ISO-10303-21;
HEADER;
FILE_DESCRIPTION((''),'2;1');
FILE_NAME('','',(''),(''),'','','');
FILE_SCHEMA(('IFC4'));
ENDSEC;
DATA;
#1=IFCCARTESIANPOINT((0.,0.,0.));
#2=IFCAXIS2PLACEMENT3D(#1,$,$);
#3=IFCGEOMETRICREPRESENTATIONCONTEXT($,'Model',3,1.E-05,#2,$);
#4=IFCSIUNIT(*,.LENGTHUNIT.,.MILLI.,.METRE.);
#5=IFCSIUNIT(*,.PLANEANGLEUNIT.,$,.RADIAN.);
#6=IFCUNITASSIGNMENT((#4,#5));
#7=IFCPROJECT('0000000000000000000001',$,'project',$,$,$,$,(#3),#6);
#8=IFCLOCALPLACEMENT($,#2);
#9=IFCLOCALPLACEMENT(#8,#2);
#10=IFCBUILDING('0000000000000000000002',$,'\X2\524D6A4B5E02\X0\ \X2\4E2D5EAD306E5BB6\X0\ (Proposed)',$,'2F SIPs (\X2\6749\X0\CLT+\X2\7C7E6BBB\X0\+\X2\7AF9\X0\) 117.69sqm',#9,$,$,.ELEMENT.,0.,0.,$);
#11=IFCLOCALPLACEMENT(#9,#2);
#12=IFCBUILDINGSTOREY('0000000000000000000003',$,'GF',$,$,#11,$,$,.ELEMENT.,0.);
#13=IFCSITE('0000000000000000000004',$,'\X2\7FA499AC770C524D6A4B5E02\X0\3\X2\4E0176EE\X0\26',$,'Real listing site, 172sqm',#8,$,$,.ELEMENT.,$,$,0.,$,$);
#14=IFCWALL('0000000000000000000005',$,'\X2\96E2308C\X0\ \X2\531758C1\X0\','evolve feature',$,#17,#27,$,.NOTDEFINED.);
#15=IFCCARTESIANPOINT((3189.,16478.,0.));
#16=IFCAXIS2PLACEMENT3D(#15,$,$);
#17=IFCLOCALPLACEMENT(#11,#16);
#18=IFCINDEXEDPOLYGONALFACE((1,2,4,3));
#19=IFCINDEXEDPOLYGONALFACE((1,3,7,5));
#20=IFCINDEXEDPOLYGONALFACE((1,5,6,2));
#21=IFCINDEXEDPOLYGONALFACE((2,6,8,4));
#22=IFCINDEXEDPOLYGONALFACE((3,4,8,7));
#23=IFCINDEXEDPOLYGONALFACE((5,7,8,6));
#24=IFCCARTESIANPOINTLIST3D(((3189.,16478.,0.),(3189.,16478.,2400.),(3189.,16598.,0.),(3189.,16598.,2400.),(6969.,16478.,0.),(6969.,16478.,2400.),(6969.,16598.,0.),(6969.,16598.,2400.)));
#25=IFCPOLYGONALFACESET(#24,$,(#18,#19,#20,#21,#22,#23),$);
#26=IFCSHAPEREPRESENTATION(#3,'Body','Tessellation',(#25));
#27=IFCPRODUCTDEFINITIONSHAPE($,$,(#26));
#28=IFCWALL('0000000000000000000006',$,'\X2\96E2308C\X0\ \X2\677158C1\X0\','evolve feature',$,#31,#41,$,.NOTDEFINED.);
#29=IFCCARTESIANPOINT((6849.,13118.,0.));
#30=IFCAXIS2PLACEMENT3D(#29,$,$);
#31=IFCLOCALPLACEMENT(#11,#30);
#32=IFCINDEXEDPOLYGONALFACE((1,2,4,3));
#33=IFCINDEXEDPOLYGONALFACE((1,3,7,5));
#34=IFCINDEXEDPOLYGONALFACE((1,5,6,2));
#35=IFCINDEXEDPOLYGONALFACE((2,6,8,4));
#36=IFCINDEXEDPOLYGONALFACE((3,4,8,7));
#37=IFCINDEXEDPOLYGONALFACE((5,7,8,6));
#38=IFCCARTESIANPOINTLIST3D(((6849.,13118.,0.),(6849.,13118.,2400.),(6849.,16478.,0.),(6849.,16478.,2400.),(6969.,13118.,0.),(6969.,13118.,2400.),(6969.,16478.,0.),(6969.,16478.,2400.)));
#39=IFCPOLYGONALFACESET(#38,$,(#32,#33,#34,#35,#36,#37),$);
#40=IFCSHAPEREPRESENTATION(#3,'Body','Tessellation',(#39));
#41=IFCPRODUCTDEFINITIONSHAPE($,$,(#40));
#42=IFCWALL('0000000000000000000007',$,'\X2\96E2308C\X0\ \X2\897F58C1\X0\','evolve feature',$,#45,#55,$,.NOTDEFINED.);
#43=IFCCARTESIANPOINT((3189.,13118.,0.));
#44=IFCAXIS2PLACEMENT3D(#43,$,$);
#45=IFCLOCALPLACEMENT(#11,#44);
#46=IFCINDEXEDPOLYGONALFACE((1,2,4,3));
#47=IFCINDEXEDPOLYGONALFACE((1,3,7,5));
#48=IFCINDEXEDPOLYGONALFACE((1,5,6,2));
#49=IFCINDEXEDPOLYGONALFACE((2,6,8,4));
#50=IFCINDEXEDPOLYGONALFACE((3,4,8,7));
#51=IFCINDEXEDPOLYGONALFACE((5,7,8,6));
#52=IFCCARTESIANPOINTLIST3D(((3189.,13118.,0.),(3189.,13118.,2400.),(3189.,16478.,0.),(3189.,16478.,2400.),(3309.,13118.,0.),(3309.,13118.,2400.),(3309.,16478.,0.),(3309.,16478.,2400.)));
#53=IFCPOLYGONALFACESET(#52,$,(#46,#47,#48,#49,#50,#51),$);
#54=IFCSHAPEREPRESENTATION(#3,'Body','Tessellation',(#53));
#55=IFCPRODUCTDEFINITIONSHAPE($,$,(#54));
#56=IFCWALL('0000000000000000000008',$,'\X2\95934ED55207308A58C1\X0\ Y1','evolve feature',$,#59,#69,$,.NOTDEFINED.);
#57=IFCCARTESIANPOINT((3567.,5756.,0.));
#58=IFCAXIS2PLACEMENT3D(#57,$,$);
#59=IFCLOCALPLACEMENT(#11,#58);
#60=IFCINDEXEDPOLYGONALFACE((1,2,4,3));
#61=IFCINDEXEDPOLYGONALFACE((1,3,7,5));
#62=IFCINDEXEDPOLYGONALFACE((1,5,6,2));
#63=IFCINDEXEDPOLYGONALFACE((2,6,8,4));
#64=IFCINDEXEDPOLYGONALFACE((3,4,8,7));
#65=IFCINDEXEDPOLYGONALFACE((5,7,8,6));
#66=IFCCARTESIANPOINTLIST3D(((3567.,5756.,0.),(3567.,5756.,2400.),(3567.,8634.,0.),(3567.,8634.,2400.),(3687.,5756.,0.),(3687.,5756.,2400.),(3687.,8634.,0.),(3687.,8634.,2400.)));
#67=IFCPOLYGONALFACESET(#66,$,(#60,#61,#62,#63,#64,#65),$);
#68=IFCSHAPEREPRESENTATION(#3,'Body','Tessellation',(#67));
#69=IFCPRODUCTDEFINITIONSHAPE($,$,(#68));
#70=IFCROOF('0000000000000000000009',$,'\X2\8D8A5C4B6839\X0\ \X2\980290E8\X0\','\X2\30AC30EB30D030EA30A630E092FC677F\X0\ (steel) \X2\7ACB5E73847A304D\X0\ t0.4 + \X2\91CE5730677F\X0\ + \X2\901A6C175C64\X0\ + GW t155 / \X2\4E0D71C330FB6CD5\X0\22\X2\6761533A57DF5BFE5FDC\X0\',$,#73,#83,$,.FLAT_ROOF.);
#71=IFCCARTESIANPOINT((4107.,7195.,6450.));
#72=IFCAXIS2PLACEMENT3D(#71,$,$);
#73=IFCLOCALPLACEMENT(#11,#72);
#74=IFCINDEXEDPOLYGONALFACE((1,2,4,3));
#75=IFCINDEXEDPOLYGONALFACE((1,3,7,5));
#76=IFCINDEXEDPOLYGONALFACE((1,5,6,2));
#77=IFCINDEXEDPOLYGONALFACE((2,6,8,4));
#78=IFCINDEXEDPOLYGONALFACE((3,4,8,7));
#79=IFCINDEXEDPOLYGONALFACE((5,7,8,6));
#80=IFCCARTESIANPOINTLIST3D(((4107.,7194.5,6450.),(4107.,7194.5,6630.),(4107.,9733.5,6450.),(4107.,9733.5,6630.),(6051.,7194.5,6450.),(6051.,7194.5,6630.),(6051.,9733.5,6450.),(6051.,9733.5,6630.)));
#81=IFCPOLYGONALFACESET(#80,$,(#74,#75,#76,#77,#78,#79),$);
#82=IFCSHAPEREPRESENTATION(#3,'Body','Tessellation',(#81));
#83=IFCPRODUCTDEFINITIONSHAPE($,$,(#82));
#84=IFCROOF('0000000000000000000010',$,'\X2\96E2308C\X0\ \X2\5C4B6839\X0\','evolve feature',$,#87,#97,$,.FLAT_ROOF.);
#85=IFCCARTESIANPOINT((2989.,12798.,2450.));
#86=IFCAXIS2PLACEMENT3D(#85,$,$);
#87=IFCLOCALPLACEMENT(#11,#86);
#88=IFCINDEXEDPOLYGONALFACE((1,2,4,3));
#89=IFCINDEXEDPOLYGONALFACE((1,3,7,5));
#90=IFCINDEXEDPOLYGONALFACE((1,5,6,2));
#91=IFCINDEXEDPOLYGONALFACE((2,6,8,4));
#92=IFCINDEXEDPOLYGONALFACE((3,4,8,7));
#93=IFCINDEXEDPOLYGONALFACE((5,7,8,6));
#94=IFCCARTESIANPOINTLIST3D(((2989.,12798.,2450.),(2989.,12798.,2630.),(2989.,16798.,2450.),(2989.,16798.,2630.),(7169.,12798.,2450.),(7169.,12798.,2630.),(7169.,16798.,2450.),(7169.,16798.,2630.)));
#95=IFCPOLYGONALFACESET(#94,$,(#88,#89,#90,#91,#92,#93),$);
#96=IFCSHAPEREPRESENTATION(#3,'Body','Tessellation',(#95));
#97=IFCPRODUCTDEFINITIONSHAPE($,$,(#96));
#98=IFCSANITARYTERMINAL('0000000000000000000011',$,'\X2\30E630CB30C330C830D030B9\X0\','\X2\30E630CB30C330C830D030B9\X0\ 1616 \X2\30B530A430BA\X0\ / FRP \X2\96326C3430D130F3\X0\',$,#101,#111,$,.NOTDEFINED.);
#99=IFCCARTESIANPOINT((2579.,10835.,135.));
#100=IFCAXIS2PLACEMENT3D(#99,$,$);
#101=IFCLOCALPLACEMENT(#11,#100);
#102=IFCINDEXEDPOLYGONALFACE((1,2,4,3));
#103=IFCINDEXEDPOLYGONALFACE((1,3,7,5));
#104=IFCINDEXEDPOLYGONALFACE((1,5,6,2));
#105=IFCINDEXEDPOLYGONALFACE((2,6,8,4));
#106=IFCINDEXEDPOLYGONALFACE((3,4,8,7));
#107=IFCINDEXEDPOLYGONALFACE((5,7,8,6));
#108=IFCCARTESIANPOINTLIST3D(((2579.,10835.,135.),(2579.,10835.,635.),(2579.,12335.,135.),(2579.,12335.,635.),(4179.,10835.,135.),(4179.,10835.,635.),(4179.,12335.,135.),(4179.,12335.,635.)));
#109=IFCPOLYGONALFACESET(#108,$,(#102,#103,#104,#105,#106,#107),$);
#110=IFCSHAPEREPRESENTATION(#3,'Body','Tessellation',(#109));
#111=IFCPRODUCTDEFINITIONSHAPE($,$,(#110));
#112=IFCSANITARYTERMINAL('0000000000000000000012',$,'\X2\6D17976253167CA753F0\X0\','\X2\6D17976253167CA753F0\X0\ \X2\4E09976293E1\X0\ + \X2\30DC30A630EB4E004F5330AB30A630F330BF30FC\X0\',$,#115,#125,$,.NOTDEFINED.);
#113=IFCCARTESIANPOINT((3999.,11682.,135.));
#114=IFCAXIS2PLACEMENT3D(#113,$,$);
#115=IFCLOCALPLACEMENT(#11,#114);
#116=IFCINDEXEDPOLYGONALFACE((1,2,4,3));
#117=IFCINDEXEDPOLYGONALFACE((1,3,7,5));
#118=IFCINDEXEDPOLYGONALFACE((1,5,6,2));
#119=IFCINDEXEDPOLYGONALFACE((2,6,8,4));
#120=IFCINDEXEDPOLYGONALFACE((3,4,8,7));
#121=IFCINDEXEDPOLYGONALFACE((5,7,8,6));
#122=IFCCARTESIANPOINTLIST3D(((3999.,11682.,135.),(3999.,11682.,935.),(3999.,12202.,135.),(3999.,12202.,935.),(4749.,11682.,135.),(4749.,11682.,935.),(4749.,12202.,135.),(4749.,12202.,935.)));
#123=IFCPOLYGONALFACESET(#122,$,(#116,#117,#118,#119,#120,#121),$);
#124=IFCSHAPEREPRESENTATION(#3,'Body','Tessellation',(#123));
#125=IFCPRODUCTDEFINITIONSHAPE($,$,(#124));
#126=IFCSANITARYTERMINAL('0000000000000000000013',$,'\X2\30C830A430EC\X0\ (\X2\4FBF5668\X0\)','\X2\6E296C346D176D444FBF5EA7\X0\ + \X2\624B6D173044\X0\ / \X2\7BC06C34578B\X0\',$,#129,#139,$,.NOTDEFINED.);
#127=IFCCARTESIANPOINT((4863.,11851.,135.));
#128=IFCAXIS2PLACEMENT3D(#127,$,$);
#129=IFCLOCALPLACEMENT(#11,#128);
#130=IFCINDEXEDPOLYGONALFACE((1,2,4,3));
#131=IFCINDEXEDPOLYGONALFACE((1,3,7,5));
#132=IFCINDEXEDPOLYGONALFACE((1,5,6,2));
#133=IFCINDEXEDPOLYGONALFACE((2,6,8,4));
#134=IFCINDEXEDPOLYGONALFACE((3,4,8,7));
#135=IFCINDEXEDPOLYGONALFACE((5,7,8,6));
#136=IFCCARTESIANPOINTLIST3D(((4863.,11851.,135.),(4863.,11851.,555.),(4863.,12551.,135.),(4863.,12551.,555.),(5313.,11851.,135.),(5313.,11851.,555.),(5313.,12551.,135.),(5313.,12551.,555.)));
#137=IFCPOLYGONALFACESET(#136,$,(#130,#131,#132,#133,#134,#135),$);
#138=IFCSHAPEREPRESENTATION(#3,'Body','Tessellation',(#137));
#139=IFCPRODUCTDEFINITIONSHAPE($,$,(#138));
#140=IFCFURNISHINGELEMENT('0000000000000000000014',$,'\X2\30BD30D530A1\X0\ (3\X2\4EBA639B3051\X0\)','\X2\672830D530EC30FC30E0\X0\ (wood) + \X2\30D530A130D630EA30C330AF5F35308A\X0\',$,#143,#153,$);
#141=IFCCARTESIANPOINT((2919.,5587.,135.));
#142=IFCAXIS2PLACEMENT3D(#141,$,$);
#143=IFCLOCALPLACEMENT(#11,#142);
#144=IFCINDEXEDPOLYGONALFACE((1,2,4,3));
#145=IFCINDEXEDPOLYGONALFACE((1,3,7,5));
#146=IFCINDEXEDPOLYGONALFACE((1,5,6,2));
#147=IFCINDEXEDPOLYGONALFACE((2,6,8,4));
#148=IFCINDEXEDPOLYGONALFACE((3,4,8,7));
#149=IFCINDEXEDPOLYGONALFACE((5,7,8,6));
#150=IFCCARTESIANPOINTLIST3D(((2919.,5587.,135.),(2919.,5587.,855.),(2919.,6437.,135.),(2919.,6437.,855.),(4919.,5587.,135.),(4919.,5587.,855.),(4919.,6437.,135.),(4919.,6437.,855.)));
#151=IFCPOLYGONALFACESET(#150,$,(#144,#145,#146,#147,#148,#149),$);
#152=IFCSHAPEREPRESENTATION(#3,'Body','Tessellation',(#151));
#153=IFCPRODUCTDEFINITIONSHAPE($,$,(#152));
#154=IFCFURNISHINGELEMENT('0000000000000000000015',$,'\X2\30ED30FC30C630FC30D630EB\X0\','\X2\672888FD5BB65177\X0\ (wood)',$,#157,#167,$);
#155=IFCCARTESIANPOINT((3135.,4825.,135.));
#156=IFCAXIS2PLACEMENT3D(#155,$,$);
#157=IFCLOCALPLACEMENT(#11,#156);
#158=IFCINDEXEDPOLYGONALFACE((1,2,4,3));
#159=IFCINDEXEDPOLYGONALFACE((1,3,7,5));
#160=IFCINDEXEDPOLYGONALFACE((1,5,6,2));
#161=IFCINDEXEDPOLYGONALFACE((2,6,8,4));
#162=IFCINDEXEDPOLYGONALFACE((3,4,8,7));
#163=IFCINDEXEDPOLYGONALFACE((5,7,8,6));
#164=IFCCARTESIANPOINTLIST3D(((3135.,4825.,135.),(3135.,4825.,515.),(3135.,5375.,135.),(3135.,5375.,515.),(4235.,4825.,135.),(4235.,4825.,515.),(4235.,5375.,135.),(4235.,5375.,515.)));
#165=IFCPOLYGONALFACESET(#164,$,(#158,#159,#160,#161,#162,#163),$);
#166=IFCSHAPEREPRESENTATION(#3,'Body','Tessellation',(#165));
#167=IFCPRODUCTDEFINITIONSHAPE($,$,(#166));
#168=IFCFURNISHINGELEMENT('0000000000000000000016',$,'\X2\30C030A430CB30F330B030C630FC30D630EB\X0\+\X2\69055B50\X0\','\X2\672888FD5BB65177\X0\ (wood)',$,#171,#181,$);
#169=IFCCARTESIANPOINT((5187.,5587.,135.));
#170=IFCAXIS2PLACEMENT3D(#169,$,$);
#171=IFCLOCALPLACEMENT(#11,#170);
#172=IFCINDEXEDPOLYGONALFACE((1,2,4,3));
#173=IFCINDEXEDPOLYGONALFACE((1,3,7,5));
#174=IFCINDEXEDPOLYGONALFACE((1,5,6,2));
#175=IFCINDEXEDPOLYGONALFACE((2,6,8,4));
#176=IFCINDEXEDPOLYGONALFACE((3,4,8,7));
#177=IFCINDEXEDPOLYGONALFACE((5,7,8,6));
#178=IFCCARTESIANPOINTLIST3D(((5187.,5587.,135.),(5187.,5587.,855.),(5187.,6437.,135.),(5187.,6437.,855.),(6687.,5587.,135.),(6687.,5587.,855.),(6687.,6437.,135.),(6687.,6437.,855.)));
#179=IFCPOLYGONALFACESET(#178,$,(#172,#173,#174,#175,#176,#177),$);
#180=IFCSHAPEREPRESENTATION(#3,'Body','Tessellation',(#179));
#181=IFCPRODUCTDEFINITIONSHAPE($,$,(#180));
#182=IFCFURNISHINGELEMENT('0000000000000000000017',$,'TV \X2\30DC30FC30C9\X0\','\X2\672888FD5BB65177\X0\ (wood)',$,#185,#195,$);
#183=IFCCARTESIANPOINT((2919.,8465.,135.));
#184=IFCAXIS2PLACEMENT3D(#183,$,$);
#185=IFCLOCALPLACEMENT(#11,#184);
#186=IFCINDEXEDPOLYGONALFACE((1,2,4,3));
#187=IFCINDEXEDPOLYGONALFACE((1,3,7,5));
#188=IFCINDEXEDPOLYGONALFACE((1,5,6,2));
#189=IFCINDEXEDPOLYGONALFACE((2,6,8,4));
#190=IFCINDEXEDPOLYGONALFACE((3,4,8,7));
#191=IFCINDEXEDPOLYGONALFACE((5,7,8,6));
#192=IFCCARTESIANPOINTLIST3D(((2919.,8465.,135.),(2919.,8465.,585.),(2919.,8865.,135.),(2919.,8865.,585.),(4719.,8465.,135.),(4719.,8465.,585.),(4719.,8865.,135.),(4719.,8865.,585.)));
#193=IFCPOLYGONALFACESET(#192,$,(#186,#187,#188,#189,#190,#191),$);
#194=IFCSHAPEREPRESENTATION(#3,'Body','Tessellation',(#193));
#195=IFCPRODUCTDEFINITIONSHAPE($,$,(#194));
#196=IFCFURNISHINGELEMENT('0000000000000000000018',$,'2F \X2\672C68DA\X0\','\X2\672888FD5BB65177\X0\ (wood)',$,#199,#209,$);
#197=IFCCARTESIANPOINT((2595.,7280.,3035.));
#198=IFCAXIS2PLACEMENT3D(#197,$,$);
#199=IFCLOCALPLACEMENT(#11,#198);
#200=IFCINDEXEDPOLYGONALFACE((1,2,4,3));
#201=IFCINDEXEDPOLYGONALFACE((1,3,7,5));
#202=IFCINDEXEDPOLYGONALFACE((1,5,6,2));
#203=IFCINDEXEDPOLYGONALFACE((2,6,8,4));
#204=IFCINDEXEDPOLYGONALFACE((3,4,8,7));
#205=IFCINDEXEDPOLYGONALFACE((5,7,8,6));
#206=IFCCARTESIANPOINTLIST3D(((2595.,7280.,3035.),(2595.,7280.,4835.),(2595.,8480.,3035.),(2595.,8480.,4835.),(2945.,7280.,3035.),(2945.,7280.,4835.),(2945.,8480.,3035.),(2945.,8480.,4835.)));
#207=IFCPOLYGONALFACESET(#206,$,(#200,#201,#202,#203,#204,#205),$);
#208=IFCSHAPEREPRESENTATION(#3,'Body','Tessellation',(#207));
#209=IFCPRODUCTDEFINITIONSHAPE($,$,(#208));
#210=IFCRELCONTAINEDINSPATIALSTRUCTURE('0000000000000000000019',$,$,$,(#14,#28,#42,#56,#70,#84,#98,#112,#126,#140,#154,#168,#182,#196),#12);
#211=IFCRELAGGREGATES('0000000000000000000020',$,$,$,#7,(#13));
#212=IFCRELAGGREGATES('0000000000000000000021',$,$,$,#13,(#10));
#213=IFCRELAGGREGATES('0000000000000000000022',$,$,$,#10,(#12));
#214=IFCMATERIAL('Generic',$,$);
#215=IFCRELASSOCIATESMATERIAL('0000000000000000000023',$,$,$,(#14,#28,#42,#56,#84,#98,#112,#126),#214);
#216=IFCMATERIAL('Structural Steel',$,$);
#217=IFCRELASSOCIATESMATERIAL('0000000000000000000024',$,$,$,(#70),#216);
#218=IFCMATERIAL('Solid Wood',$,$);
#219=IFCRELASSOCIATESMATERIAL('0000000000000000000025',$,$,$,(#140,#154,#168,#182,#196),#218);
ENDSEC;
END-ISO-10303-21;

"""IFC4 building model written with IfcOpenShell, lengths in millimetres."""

from ifc_helpers import new_model, si_unit, frame, frame_2d, origin, place, context, project, spatial, rectangle, extrude, material, element, save


model = new_model("IFC4")

# Units and contexts
model_context = context("Model", 3, precision=1e-05, world=origin())
ifc_project = project(units=[si_unit("LENGTHUNIT", "METRE", prefix="MILLI"), si_unit("PLANEANGLEUNIT", "RADIAN")], contexts=[model_context])

# Site, building, storey
site_placement = place(None, origin())
site = spatial("IfcSite", under=ifc_project, at=site_placement, Name="群馬県前橋市3丁目26", ObjectType="Real listing site, 172sqm", CompositionType="ELEMENT", RefElevation=0.0)
building_placement = place(site_placement, origin())
building = spatial("IfcBuilding", under=site, at=building_placement, Name="前橋市 中庭の家 (Proposed)", ObjectType="2F SIPs (杉CLT+籾殻+竹) 117.69sqm", CompositionType="ELEMENT", ElevationOfRefHeight=0.0, ElevationOfTerrain=0.0)
storey_placement = place(building_placement, origin())
storey = spatial("IfcBuildingStorey", under=building, at=storey_placement, Name="GF", CompositionType="ELEMENT", Elevation=0.0)

# Shared definitions
ifc_material_1 = material(Name="Generic")

# Shared definitions
ifc_material_2 = material(Name="Solid Wood")

# Walls
wall_1_placement = place(storey_placement, frame((3189.0, 16478.0, 0.0)))
element("IfcWall", 1, at=wall_1_placement, inside=storey, material=ifc_material_1, Name="離れ 北壁", Description="evolve feature", PredefinedType="NOTDEFINED", context=model_context, shape_type="SweptSolid", body=[
    extrude(rectangle(XDim=3780.0, YDim=120.0, at=frame_2d((1890.0, 60.0))), frame((3189.0, 16478.0, 0.0)), (0.0, 0.0, 1.0), 2400.0),
])
wall_2_placement = place(storey_placement, frame((6849.0, 13118.0, 0.0)))
element("IfcWall", 2, at=wall_2_placement, inside=storey, material=ifc_material_1, Name="離れ 東壁", Description="evolve feature", PredefinedType="NOTDEFINED", context=model_context, shape_type="SweptSolid", body=[
    extrude(rectangle(XDim=120.0, YDim=3360.0, at=frame_2d((60.0, 1680.0))), frame((6849.0, 13118.0, 0.0)), (0.0, 0.0, 1.0), 2400.0),
])
wall_3_placement = place(storey_placement, frame((3189.0, 13118.0, 0.0)))
element("IfcWall", 3, at=wall_3_placement, inside=storey, material=ifc_material_1, Name="離れ 西壁", Description="evolve feature", PredefinedType="NOTDEFINED", context=model_context, shape_type="SweptSolid", body=[
    extrude(rectangle(XDim=120.0, YDim=3360.0, at=frame_2d((60.0, 1680.0))), frame((3189.0, 13118.0, 0.0)), (0.0, 0.0, 1.0), 2400.0),
])
wall_4_placement = place(storey_placement, frame((3567.0, 5756.0, 0.0)))
element("IfcWall", 4, at=wall_4_placement, inside=storey, material=ifc_material_1, Name="間仕切り壁 Y1", Description="evolve feature", PredefinedType="NOTDEFINED", context=model_context, shape_type="SweptSolid", body=[
    extrude(rectangle(XDim=120.0, YDim=2878.0, at=frame_2d((60.0, 1439.0))), frame((3567.0, 5756.0, 0.0)), (0.0, 0.0, 1.0), 2400.0),
])

# Roofs
ifc_material_3 = material(Name="Structural Steel")
roof_1_placement = place(storey_placement, frame((4107.0, 7195.0, 6450.0)))
element("IfcRoof", 5, at=roof_1_placement, inside=storey, material=ifc_material_3, Name="越屋根 頂部", Description="ガルバリウム鋼板 (steel) 立平葺き t0.4 + 野地板 + 通気層 + GW t155 / 不燃・法22条区域対応", PredefinedType="FLAT_ROOF", context=model_context, shape_type="SweptSolid", body=[
    extrude(rectangle(XDim=1944.0, YDim=2539.0, at=frame_2d((972.0, 1269.0))), frame((4107.0, 7195.0, 6450.0)), (0.0, 0.0, 1.0), 180.0),
])
roof_2_placement = place(storey_placement, frame((2989.0, 12798.0, 2450.0)))
element("IfcRoof", 6, at=roof_2_placement, inside=storey, material=ifc_material_1, Name="離れ 屋根", Description="evolve feature", PredefinedType="FLAT_ROOF", context=model_context, shape_type="SweptSolid", body=[
    extrude(rectangle(XDim=4180.0, YDim=4000.0, at=frame_2d((2090.0, 2000.0))), frame((2989.0, 12798.0, 2450.0)), (0.0, 0.0, 1.0), 180.0),
])

# Sanitary terminals
sanitary_terminal_1_placement = place(storey_placement, frame((2579.0, 10835.0, 135.0)))
element("IfcSanitaryTerminal", 7, at=sanitary_terminal_1_placement, inside=storey, material=ifc_material_1, Name="ユニットバス", Description="ユニットバス 1616 サイズ / FRP 防水パン", PredefinedType="NOTDEFINED", context=model_context, shape_type="SweptSolid", body=[
    extrude(rectangle(XDim=1600.0, YDim=1500.0, at=frame_2d((800.0, 750.0))), frame((2579.0, 10835.0, 135.0)), (0.0, 0.0, 1.0), 500.0),
])
sanitary_terminal_2_placement = place(storey_placement, frame((3999.0, 11682.0, 135.0)))
element("IfcSanitaryTerminal", 8, at=sanitary_terminal_2_placement, inside=storey, material=ifc_material_1, Name="洗面化粧台", Description="洗面化粧台 三面鏡 + ボウル一体カウンター", PredefinedType="NOTDEFINED", context=model_context, shape_type="SweptSolid", body=[
    extrude(rectangle(XDim=750.0, YDim=520.0, at=frame_2d((375.0, 260.0))), frame((3999.0, 11682.0, 135.0)), (0.0, 0.0, 1.0), 800.0),
])
sanitary_terminal_3_placement = place(storey_placement, frame((4863.0, 11851.0, 135.0)))
element("IfcSanitaryTerminal", 9, at=sanitary_terminal_3_placement, inside=storey, material=ifc_material_1, Name="トイレ (便器)", Description="温水洗浄便座 + 手洗い / 節水型", PredefinedType="NOTDEFINED", context=model_context, shape_type="SweptSolid", body=[
    extrude(rectangle(XDim=450.0, YDim=700.0, at=frame_2d((225.0, 350.0))), frame((4863.0, 11851.0, 135.0)), (0.0, 0.0, 1.0), 420.0),
])

# Furnishing elements
furnishing_1_placement = place(storey_placement, frame((2919.0, 5587.0, 135.0)))
element("IfcFurnishingElement", 10, at=furnishing_1_placement, inside=storey, material=ifc_material_2, Name="ソファ (3人掛け)", Description="木フレーム (wood) + ファブリック張り", context=model_context, shape_type="SweptSolid", body=[
    extrude(rectangle(XDim=2000.0, YDim=850.0, at=frame_2d((1000.0, 425.0))), frame((2919.0, 5587.0, 135.0)), (0.0, 0.0, 1.0), 720.0),
])
furnishing_2_placement = place(storey_placement, frame((3135.0, 4825.0, 135.0)))
element("IfcFurnishingElement", 11, at=furnishing_2_placement, inside=storey, material=ifc_material_2, Name="ローテーブル", Description="木製家具 (wood)", context=model_context, shape_type="SweptSolid", body=[
    extrude(rectangle(XDim=1100.0, YDim=550.0, at=frame_2d((550.0, 275.0))), frame((3135.0, 4825.0, 135.0)), (0.0, 0.0, 1.0), 380.0),
])
furnishing_3_placement = place(storey_placement, frame((5187.0, 5587.0, 135.0)))
element("IfcFurnishingElement", 12, at=furnishing_3_placement, inside=storey, material=ifc_material_2, Name="ダイニングテーブル+椅子", Description="木製家具 (wood)", context=model_context, shape_type="SweptSolid", body=[
    extrude(rectangle(XDim=1500.0, YDim=850.0, at=frame_2d((750.0, 425.0))), frame((5187.0, 5587.0, 135.0)), (0.0, 0.0, 1.0), 720.0),
])
furnishing_4_placement = place(storey_placement, frame((2919.0, 8465.0, 135.0)))
element("IfcFurnishingElement", 13, at=furnishing_4_placement, inside=storey, material=ifc_material_2, Name="TV ボード", Description="木製家具 (wood)", context=model_context, shape_type="SweptSolid", body=[
    extrude(rectangle(XDim=1800.0, YDim=400.0, at=frame_2d((900.0, 200.0))), frame((2919.0, 8465.0, 135.0)), (0.0, 0.0, 1.0), 450.0),
])
furnishing_5_placement = place(storey_placement, frame((2595.0, 7280.0, 3035.0)))
element("IfcFurnishingElement", 14, at=furnishing_5_placement, inside=storey, material=ifc_material_2, Name="2F 本棚", Description="木製家具 (wood)", context=model_context, shape_type="SweptSolid", body=[
    extrude(rectangle(XDim=350.0, YDim=1200.0, at=frame_2d((175.0, 600.0))), frame((2595.0, 7280.0, 3035.0)), (0.0, 0.0, 1.0), 1800.0),
])

save(model, "model.ifc")
